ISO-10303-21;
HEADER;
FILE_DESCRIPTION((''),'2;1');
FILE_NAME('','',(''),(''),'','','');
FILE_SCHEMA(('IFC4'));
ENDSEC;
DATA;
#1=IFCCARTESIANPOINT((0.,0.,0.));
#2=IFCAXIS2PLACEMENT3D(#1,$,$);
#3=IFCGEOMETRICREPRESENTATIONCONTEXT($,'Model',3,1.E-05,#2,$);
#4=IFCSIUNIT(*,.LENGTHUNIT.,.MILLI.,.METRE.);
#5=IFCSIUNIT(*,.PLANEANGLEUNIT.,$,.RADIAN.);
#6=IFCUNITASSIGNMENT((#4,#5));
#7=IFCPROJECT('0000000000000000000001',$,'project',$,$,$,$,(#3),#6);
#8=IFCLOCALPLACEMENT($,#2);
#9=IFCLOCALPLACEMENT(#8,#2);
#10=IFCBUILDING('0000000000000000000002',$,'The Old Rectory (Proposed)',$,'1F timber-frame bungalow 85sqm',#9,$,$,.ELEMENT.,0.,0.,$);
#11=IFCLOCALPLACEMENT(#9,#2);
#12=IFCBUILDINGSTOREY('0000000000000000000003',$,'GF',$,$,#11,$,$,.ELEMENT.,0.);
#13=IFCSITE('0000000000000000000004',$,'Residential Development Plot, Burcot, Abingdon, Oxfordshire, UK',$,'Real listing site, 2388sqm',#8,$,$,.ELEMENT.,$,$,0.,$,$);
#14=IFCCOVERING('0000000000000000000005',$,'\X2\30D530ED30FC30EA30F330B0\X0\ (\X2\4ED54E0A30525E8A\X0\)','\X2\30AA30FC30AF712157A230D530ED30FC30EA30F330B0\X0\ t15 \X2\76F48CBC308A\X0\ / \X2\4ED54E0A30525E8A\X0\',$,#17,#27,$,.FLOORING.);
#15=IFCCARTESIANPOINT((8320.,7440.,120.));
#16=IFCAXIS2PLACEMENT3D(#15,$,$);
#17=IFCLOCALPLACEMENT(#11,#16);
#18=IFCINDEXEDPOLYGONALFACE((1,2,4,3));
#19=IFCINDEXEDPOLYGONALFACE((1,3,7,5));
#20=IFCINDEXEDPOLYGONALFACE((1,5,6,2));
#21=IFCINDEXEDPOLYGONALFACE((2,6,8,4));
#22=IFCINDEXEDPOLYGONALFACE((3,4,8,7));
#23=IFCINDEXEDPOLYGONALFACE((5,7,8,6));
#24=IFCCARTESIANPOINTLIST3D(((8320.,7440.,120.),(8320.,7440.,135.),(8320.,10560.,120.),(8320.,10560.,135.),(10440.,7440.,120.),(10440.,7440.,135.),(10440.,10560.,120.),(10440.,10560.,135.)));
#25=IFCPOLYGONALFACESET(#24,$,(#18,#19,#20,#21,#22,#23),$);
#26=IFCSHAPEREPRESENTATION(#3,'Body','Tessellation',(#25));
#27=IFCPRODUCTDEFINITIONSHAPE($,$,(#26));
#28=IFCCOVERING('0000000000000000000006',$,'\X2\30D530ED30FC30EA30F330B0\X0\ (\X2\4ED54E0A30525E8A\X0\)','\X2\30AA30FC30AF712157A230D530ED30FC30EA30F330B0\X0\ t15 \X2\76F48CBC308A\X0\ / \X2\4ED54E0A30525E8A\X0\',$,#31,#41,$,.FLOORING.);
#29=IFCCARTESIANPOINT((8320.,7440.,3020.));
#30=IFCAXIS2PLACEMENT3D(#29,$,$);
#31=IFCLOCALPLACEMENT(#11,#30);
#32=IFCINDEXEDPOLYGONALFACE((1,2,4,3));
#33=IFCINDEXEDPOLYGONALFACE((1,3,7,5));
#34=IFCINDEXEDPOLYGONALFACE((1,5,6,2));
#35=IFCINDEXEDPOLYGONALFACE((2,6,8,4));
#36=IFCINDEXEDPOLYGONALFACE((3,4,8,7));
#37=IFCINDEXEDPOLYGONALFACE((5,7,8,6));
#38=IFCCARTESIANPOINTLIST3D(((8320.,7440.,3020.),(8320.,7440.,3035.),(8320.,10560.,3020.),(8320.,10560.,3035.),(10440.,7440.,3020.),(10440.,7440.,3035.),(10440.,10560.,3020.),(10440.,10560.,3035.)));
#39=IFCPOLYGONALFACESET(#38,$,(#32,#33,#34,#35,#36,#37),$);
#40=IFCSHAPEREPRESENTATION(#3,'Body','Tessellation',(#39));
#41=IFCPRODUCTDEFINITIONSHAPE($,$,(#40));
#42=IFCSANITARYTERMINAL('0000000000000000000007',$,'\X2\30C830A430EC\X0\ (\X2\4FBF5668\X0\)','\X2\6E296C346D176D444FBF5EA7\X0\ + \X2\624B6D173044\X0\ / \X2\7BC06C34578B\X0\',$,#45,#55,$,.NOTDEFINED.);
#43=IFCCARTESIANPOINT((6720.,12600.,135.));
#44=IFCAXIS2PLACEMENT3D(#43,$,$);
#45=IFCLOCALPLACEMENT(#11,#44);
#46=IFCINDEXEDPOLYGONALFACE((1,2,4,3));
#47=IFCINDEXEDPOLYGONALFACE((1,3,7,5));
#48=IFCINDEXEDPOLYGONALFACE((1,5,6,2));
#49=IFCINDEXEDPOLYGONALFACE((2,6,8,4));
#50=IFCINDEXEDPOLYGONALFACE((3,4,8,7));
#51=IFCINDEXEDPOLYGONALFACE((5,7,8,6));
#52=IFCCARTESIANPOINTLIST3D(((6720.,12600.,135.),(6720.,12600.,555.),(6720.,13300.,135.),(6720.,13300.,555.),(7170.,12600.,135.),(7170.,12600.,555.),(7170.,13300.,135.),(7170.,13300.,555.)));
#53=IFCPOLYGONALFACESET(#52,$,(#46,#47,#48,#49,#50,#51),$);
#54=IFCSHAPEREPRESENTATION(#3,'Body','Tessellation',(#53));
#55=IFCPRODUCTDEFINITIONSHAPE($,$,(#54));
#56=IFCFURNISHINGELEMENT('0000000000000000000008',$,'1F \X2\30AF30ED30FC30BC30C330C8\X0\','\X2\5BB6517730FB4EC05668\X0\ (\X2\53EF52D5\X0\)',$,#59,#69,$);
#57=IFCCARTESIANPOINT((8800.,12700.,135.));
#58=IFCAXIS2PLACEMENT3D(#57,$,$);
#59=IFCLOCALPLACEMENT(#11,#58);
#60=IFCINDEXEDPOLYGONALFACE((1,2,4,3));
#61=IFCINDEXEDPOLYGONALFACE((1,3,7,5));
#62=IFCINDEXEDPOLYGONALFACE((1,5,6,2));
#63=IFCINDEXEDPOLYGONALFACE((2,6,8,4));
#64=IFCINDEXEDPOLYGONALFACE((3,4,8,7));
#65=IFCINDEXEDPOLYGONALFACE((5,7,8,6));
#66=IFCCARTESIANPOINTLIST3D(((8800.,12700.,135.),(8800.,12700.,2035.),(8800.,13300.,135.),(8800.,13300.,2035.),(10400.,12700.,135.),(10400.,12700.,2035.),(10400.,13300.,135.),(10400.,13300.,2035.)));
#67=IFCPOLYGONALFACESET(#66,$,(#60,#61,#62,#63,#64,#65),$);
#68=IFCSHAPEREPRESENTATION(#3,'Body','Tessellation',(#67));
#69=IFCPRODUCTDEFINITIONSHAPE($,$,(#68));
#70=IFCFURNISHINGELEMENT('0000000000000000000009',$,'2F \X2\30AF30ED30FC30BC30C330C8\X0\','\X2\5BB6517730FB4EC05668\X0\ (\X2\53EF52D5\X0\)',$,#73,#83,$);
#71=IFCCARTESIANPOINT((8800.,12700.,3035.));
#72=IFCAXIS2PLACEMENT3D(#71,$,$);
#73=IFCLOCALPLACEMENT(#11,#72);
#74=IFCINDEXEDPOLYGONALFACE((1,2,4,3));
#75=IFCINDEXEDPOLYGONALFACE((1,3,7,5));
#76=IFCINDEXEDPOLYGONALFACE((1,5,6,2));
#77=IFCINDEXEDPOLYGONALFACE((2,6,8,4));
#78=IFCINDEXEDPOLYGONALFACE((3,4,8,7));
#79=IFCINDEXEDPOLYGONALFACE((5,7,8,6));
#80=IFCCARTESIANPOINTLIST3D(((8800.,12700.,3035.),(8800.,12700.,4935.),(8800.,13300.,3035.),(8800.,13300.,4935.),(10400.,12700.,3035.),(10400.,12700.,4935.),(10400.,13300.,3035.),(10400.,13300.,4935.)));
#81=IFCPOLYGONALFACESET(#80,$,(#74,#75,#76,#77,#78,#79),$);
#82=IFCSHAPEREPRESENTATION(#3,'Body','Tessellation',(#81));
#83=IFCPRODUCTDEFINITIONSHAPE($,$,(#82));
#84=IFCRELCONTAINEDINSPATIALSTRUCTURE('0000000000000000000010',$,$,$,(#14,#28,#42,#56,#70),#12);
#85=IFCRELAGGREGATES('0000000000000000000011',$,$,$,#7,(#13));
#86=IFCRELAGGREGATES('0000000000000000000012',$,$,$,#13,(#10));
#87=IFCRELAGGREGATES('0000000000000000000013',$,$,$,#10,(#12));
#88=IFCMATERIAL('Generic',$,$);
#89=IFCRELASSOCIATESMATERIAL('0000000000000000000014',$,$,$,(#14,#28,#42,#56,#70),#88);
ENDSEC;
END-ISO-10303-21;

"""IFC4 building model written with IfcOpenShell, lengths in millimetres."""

from ifc_helpers import new_model, si_unit, frame, frame_2d, origin, place, context, project, spatial, rectangle, extrude, material, element, save


model = new_model("IFC4")

# Units and contexts
model_context = context("Model", 3, precision=1e-05, world=origin())
ifc_project = project(units=[si_unit("LENGTHUNIT", "METRE", prefix="MILLI"), si_unit("PLANEANGLEUNIT", "RADIAN")], contexts=[model_context])

# Site, building, storey
site_placement = place(None, origin())
site = spatial("IfcSite", under=ifc_project, at=site_placement, Name="Residential Development Plot, Burcot, Abingdon, Oxfordshire, UK", ObjectType="Real listing site, 2388sqm", CompositionType="ELEMENT", RefElevation=0.0)
building_placement = place(site_placement, origin())
building = spatial("IfcBuilding", under=site, at=building_placement, Name="The Old Rectory (Proposed)", ObjectType="1F timber-frame bungalow 85sqm", CompositionType="ELEMENT", ElevationOfRefHeight=0.0, ElevationOfTerrain=0.0)
storey_placement = place(building_placement, origin())
storey = spatial("IfcBuildingStorey", under=building, at=storey_placement, Name="GF", CompositionType="ELEMENT", Elevation=0.0)

# Shared definitions
ifc_material_1 = material(Name="Generic")

# Coverings
covering_1_placement = place(storey_placement, frame((8320.0, 7440.0, 120.0)))
element("IfcCovering", 1, at=covering_1_placement, inside=storey, material=ifc_material_1, Name="フローリング (仕上げ床)", Description="オーク無垢フローリング t15 直貼り / 仕上げ床", PredefinedType="FLOORING", context=model_context, shape_type="SweptSolid", body=[
    extrude(rectangle(XDim=2120.0, YDim=3120.0, at=frame_2d((1060.0, 1560.0))), frame((8320.0, 7440.0, 120.0)), (0.0, 0.0, 1.0), 15.0),
])
covering_2_placement = place(storey_placement, frame((8320.0, 7440.0, 3020.0)))
element("IfcCovering", 2, at=covering_2_placement, inside=storey, material=ifc_material_1, Name="フローリング (仕上げ床)", Description="オーク無垢フローリング t15 直貼り / 仕上げ床", PredefinedType="FLOORING", context=model_context, shape_type="SweptSolid", body=[
    extrude(rectangle(XDim=2120.0, YDim=3120.0, at=frame_2d((1060.0, 1560.0))), frame((8320.0, 7440.0, 3020.0)), (0.0, 0.0, 1.0), 15.0),
])

# Sanitary terminal
sanitary_terminal_placement = place(storey_placement, frame((6720.0, 12600.0, 135.0)))
element("IfcSanitaryTerminal", 3, at=sanitary_terminal_placement, inside=storey, material=ifc_material_1, Name="トイレ (便器)", Description="温水洗浄便座 + 手洗い / 節水型", PredefinedType="NOTDEFINED", context=model_context, shape_type="SweptSolid", body=[
    extrude(rectangle(XDim=450.0, YDim=700.0, at=frame_2d((225.0, 350.0))), frame((6720.0, 12600.0, 135.0)), (0.0, 0.0, 1.0), 420.0),
])

# Furnishing elements
furnishing_1_placement = place(storey_placement, frame((8800.0, 12700.0, 135.0)))
element("IfcFurnishingElement", 4, at=furnishing_1_placement, inside=storey, material=ifc_material_1, Name="1F クローゼット", Description="家具・什器 (可動)", context=model_context, shape_type="SweptSolid", body=[
    extrude(rectangle(XDim=1600.0, YDim=600.0, at=frame_2d((800.0, 300.0))), frame((8800.0, 12700.0, 135.0)), (0.0, 0.0, 1.0), 1900.0),
])
furnishing_2_placement = place(storey_placement, frame((8800.0, 12700.0, 3035.0)))
element("IfcFurnishingElement", 5, at=furnishing_2_placement, inside=storey, material=ifc_material_1, Name="2F クローゼット", Description="家具・什器 (可動)", context=model_context, shape_type="SweptSolid", body=[
    extrude(rectangle(XDim=1600.0, YDim=600.0, at=frame_2d((800.0, 300.0))), frame((8800.0, 12700.0, 3035.0)), (0.0, 0.0, 1.0), 1900.0),
])

save(model, "model.ifc")
